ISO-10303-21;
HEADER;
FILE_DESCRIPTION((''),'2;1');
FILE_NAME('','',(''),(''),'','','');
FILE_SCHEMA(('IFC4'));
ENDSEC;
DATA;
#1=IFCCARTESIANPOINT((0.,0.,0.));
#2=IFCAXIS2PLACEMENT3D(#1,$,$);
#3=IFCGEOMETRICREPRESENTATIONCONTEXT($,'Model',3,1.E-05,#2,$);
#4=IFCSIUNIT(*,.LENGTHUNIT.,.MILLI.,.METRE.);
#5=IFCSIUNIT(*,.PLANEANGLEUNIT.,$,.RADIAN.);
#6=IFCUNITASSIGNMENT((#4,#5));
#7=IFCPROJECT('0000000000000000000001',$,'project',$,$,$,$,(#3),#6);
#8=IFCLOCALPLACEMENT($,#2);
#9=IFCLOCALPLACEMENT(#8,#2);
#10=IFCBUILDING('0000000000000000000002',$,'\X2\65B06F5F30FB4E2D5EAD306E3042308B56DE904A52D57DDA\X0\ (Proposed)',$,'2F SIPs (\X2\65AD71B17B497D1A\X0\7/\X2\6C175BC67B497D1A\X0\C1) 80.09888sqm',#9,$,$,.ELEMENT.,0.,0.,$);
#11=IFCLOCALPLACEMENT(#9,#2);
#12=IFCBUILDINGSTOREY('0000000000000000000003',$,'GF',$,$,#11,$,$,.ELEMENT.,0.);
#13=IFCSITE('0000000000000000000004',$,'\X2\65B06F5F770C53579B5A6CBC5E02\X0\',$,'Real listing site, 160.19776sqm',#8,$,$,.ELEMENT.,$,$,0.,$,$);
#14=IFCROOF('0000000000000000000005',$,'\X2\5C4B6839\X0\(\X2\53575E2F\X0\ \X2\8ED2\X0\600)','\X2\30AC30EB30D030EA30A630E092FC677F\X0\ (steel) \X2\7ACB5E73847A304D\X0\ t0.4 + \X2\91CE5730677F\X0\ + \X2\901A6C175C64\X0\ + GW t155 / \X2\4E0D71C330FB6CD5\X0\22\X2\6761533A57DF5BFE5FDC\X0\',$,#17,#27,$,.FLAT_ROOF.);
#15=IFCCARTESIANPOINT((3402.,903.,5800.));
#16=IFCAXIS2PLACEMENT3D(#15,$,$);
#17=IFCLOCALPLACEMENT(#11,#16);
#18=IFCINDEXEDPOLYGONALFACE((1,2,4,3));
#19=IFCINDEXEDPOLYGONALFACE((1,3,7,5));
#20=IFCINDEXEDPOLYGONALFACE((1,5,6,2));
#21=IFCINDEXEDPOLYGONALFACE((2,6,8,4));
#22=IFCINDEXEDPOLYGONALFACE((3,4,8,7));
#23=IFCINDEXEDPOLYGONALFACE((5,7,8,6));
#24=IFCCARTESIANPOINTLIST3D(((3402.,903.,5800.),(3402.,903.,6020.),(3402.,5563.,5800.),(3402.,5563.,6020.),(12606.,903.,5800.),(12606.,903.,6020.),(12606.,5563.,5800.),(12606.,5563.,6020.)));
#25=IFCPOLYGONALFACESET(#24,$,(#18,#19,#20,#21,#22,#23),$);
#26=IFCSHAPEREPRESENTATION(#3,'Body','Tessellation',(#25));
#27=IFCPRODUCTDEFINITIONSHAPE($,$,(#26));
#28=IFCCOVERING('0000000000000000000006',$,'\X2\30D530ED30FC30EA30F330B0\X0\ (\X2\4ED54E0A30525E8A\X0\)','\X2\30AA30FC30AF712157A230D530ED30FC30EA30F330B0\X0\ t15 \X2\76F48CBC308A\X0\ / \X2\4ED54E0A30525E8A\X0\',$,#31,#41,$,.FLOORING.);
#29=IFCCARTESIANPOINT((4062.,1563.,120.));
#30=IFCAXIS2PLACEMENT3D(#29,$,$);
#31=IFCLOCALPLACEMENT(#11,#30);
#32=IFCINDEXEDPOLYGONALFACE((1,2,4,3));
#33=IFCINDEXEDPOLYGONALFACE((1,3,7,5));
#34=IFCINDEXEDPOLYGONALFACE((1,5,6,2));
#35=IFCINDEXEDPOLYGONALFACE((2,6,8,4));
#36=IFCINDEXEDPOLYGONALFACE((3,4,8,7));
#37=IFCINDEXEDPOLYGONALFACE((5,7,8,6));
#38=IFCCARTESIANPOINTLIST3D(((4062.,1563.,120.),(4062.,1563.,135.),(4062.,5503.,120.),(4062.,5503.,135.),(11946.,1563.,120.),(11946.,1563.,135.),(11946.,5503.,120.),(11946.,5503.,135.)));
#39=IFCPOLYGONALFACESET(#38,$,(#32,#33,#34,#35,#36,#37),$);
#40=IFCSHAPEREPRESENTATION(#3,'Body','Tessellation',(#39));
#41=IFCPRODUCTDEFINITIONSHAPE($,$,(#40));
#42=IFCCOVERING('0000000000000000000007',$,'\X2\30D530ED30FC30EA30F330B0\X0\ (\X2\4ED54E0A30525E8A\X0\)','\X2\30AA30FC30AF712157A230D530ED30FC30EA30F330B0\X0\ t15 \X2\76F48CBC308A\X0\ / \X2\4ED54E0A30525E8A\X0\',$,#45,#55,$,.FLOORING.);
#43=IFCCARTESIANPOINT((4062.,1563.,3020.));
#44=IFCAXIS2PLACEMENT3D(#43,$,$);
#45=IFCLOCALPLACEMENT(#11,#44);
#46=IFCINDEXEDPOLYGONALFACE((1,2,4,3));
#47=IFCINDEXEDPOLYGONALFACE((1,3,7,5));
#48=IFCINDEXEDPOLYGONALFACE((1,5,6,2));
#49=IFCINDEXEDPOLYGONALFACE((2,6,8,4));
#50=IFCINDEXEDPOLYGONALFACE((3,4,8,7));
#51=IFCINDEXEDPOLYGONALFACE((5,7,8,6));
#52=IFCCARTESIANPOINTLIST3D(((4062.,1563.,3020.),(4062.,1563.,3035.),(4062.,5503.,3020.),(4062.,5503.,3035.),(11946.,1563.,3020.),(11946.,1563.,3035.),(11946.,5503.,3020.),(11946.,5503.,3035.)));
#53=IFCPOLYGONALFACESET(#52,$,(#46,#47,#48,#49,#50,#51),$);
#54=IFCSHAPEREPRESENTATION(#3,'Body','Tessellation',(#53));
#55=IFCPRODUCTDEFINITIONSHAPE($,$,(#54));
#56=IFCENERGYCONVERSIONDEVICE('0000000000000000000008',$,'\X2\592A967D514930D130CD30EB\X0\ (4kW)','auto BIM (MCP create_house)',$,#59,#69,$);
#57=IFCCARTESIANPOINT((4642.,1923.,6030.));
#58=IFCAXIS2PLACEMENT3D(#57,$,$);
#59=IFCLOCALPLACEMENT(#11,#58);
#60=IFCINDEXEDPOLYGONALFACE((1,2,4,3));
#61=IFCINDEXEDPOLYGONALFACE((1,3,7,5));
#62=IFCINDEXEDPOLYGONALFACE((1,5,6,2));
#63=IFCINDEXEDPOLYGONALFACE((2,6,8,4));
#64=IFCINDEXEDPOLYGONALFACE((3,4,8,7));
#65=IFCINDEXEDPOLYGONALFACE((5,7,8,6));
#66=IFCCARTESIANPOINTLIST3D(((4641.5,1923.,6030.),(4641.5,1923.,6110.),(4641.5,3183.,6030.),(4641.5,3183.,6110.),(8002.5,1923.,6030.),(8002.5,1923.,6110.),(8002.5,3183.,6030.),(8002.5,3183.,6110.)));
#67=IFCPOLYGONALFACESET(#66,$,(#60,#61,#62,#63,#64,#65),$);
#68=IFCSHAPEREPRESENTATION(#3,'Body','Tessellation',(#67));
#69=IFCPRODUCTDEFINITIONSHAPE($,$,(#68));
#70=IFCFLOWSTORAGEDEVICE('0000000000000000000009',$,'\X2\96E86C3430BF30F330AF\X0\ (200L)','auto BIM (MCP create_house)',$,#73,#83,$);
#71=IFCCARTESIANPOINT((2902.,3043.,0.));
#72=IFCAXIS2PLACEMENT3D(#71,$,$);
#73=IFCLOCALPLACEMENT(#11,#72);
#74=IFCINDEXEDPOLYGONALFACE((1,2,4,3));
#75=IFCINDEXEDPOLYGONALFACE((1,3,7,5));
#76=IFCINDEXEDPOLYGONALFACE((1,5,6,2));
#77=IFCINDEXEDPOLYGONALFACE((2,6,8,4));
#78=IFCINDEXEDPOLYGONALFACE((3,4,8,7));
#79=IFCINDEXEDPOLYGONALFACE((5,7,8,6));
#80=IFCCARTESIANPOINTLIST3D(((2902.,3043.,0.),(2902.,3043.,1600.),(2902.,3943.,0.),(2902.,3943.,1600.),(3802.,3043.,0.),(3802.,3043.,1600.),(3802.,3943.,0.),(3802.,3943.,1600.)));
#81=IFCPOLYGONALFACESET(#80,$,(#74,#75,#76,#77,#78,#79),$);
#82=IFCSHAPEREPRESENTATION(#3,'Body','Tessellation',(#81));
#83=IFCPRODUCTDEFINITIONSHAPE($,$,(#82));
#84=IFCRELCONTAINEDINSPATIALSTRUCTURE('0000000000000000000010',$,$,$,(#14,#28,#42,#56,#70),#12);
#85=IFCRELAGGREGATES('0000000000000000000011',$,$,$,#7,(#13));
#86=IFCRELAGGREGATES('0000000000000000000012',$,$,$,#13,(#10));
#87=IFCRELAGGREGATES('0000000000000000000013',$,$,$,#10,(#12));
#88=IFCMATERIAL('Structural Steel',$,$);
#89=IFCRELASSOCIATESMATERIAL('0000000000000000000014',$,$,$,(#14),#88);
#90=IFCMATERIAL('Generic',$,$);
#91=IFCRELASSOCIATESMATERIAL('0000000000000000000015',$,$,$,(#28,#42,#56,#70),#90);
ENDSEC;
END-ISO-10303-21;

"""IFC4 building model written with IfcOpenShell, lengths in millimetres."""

from ifc_helpers import new_model, si_unit, frame, frame_2d, origin, place, context, project, spatial, rectangle, extrude, material, element, save


model = new_model("IFC4")

# Units and contexts
model_context = context("Model", 3, precision=1e-05, world=origin())
ifc_project = project(units=[si_unit("LENGTHUNIT", "METRE", prefix="MILLI"), si_unit("PLANEANGLEUNIT", "RADIAN")], contexts=[model_context])

# Site, building, storey
site_placement = place(None, origin())
site = spatial("IfcSite", under=ifc_project, at=site_placement, Name="新潟県南魚沼市", ObjectType="Real listing site, 160.19776sqm", CompositionType="ELEMENT", RefElevation=0.0)
building_placement = place(site_placement, origin())
building = spatial("IfcBuilding", under=site, at=building_placement, Name="新潟・中庭のある回遊動線 (Proposed)", ObjectType="2F SIPs (断熱等級7/気密等級C1) 80.09888sqm", CompositionType="ELEMENT", ElevationOfRefHeight=0.0, ElevationOfTerrain=0.0)
storey_placement = place(building_placement, origin())
storey = spatial("IfcBuildingStorey", under=building, at=storey_placement, Name="GF", CompositionType="ELEMENT", Elevation=0.0)

# Roof
ifc_material_1 = material(Name="Structural Steel")
for number, where, name in (
    (1, (3402.0, 903.0, 5800.0), "屋根(南帯 軒600)"),
):
    element("IfcRoof", number, at=place(storey_placement, frame(where)), inside=storey, material=ifc_material_1, Name=name, Description="ガルバリウム鋼板 (steel) 立平葺き t0.4 + 野地板 + 通気層 + GW t155 / 不燃・法22条区域対応", PredefinedType="FLAT_ROOF", context=model_context, shape_type="SweptSolid", body=[
        extrude(rectangle(XDim=9204.0, YDim=4660.0, at=frame_2d((4602.0, 2330.0))), frame((3402.0, 903.0, 5800.0)), (0.0, 0.0, 1.0), 220.0),
    ])

# Coverings
ifc_material_2 = material(Name="Generic")
covering_1_placement = place(storey_placement, frame((4062.0, 1563.0, 120.0)))
element("IfcCovering", 2, at=covering_1_placement, inside=storey, material=ifc_material_2, Name="フローリング (仕上げ床)", Description="オーク無垢フローリング t15 直貼り / 仕上げ床", PredefinedType="FLOORING", context=model_context, shape_type="SweptSolid", body=[
    extrude(rectangle(XDim=7884.0, YDim=3940.0, at=frame_2d((3942.0, 1970.0))), frame((4062.0, 1563.0, 120.0)), (0.0, 0.0, 1.0), 15.0),
])
covering_2_placement = place(storey_placement, frame((4062.0, 1563.0, 3020.0)))
element("IfcCovering", 3, at=covering_2_placement, inside=storey, material=ifc_material_2, Name="フローリング (仕上げ床)", Description="オーク無垢フローリング t15 直貼り / 仕上げ床", PredefinedType="FLOORING", context=model_context, shape_type="SweptSolid", body=[
    extrude(rectangle(XDim=7884.0, YDim=3940.0, at=frame_2d((3942.0, 1970.0))), frame((4062.0, 1563.0, 3020.0)), (0.0, 0.0, 1.0), 15.0),
])

# Energy conversion device
energy_conversion_device_placement = place(storey_placement, frame((4642.0, 1923.0, 6030.0)))
element("IfcEnergyConversionDevice", 4, at=energy_conversion_device_placement, inside=storey, material=ifc_material_2, Name="太陽光パネル (4kW)", Description="auto BIM (MCP create_house)", context=model_context, shape_type="SweptSolid", body=[
    extrude(rectangle(XDim=3361.0, YDim=1260.0, at=frame_2d((1680.0, 630.0))), frame((4642.0, 1923.0, 6030.0)), (0.0, 0.0, 1.0), 80.0),
])

# Flow storage device
flow_storage_device_placement = place(storey_placement, frame((2902.0, 3043.0, 0.0)))
element("IfcFlowStorageDevice", 5, at=flow_storage_device_placement, inside=storey, material=ifc_material_2, Name="雨水タンク (200L)", Description="auto BIM (MCP create_house)", context=model_context, shape_type="SweptSolid", body=[
    extrude(rectangle(XDim=900.0, YDim=900.0, at=frame_2d((450.0, 450.0))), frame((2902.0, 3043.0, 0.0)), (0.0, 0.0, 1.0), 1600.0),
])

save(model, "model.ifc")
